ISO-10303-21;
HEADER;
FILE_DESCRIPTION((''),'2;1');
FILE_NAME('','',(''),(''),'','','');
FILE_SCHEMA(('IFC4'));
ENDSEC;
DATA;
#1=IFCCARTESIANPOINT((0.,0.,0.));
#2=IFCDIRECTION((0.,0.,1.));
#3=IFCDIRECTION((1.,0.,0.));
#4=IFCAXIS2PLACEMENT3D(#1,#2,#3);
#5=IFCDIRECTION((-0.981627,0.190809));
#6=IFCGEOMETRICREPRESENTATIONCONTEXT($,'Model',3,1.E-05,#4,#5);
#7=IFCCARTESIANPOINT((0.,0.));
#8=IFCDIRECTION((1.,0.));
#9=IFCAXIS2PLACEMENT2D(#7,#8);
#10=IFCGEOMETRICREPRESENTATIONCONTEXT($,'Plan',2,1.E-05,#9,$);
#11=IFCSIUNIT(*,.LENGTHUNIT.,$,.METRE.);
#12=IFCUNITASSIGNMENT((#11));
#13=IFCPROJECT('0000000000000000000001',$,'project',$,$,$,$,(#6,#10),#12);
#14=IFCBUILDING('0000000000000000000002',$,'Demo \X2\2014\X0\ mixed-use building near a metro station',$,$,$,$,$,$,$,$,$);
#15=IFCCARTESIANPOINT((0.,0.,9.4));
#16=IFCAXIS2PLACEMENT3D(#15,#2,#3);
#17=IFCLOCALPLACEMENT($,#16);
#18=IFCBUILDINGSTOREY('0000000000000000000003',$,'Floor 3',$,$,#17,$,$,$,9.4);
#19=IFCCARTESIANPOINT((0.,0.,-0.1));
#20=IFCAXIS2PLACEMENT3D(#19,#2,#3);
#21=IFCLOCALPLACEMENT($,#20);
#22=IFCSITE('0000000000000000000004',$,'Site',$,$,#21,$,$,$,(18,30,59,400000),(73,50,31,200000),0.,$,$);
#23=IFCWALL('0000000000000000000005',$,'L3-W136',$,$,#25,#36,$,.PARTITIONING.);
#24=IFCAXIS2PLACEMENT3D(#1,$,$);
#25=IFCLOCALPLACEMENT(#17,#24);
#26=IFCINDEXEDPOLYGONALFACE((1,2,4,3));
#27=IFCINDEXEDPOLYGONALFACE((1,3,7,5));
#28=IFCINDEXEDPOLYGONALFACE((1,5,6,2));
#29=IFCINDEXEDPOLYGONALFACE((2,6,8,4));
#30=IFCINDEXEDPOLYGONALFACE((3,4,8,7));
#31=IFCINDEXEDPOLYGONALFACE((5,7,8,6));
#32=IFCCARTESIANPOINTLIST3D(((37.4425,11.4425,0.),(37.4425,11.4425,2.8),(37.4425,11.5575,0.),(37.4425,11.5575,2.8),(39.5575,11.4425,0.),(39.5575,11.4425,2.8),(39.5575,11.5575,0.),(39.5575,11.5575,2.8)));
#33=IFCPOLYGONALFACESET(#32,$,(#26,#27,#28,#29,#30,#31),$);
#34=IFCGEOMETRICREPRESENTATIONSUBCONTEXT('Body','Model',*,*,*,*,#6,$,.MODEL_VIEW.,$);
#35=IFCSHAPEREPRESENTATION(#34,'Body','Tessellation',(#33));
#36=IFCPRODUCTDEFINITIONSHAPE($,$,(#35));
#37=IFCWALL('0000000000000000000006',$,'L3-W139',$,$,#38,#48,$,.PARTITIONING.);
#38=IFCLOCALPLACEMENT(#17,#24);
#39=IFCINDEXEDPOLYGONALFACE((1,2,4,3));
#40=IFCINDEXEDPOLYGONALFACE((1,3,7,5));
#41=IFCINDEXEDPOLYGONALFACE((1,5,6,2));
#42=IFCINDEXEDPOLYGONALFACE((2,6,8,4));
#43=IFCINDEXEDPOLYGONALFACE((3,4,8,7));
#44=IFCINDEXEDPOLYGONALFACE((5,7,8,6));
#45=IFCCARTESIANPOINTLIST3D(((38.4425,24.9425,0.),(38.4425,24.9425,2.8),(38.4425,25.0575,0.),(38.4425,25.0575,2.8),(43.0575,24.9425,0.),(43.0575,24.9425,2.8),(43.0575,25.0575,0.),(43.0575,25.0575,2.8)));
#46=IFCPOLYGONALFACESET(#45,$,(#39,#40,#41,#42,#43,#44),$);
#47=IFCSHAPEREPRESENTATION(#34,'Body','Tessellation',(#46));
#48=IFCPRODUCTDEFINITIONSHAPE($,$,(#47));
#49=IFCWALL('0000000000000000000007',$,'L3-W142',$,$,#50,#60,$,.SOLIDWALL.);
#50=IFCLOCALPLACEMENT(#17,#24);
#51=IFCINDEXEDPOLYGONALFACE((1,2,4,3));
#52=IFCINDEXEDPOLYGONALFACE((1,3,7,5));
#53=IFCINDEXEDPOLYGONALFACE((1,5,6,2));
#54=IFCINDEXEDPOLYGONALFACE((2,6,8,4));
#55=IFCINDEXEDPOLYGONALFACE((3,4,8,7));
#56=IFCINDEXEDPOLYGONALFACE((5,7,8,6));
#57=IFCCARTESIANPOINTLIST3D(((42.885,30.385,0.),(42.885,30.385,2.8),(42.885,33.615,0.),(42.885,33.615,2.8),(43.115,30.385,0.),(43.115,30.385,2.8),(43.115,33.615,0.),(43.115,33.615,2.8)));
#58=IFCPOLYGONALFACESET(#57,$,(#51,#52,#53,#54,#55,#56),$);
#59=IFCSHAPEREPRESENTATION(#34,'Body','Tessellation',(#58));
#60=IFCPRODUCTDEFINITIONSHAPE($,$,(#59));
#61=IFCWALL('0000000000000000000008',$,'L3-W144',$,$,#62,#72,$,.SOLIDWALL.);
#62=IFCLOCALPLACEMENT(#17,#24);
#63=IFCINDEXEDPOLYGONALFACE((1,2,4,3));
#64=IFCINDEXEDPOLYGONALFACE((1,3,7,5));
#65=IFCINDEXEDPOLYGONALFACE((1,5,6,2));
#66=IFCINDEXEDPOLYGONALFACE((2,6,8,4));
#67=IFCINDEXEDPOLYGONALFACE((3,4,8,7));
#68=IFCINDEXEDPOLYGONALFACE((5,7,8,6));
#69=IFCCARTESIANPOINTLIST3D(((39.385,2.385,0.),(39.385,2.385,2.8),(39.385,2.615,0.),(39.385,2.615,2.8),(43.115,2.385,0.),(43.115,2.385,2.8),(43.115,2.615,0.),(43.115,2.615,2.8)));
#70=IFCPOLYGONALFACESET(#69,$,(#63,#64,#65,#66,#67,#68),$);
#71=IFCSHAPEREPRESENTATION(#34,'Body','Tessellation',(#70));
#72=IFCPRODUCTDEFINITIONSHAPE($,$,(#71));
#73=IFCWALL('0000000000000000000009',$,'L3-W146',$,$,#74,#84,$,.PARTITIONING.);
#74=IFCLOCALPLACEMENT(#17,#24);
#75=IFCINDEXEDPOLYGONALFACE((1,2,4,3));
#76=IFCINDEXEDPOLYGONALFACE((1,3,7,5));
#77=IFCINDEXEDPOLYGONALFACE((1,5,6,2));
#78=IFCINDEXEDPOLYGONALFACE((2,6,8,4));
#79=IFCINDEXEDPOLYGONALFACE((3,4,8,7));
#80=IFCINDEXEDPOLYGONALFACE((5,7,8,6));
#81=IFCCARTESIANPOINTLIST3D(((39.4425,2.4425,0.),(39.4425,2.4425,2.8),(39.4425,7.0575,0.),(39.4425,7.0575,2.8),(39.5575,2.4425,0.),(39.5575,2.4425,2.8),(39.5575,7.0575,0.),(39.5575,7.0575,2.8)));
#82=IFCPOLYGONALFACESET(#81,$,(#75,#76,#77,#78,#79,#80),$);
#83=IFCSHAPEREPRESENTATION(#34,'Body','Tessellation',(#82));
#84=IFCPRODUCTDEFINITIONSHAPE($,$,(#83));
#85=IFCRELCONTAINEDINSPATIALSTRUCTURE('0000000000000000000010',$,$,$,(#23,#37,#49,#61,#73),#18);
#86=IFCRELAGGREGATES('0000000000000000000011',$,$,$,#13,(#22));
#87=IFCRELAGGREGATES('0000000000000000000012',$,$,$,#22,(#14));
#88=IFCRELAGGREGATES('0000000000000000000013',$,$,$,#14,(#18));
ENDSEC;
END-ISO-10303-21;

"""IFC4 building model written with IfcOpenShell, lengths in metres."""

from ifc_helpers import new_model, si_unit, direction, frame, origin_with_axes, origin_2d_with_axis, place, context, subcontext, project, spatial, line, indexed_curve, outline, extrude, element, save


model = new_model("IFC4")

# Units and contexts
model_context = context("Model", 3, precision=1e-05, world=origin_with_axes(), true_north=direction((-0.981627, 0.190809)))
plan_context = context("Plan", 2, precision=1e-05, world=origin_2d_with_axis())
body_context = subcontext(model_context, "Body", "Model", "MODEL_VIEW")
ifc_project = project(units=[si_unit("LENGTHUNIT", "METRE")], contexts=[model_context, plan_context])

# Site, building, storey
site_placement = place(None, frame((0.0, 0.0, -0.1), z_axis=(0.0, 0.0, 1.0), x_axis=(1.0, 0.0, 0.0)))
site = spatial("IfcSite", under=ifc_project, at=site_placement, Name="Site", RefLatitude=(18, 30, 59, 400000), RefLongitude=(73, 50, 31, 200000), RefElevation=0.0)
building = spatial("IfcBuilding", under=site, Name="Demo — mixed-use building near a metro station")
storey_placement = place(None, frame((0.0, 0.0, 9.4), z_axis=(0.0, 0.0, 1.0), x_axis=(1.0, 0.0, 0.0)))
storey = spatial("IfcBuildingStorey", under=building, at=storey_placement, Name="Floor 3", Elevation=9.4)

# Wall
wall_1_placement = place(storey_placement, frame((0.0, 0.0, -9.4), z_axis=(0.0, 0.0, 1.0), x_axis=(1.0, 0.0, 0.0)))
element("IfcWall", 1, at=wall_1_placement, inside=storey, Name="L3-W136", PredefinedType="PARTITIONING", context=body_context, shape_type="SweptSolid", body=[
    extrude(outline(indexed_curve([(37.4425, 11.5575), (39.5575, 11.5575), (39.5575, 11.4425), (37.4425, 11.4425)], segments=[line(1, 2, 3, 4, 1)])), frame((0.0, 0.0, 9.4), z_axis=(0.0, 0.0, 1.0), x_axis=(1.0, 0.0, 0.0)), (0.0, 0.0, 1.0), 2.8),
])

# Wall
wall_2_placement = place(storey_placement, frame((0.0, 0.0, -9.4), z_axis=(0.0, 0.0, 1.0), x_axis=(1.0, 0.0, 0.0)))
element("IfcWall", 2, at=wall_2_placement, inside=storey, Name="L3-W139", PredefinedType="PARTITIONING", context=body_context, shape_type="SweptSolid", body=[
    extrude(outline(indexed_curve([(43.0575, 24.9425), (38.4425, 24.9425), (38.4425, 25.0575), (43.0575, 25.0575)], segments=[line(1, 2, 3, 4, 1)])), frame((0.0, 0.0, 9.4), z_axis=(0.0, 0.0, 1.0), x_axis=(1.0, 0.0, 0.0)), (0.0, 0.0, 1.0), 2.8),
])

# Wall
wall_3_placement = place(storey_placement, frame((0.0, 0.0, -9.4), z_axis=(0.0, 0.0, 1.0), x_axis=(1.0, 0.0, 0.0)))
element("IfcWall", 3, at=wall_3_placement, inside=storey, Name="L3-W142", PredefinedType="SOLIDWALL", context=body_context, shape_type="SweptSolid", body=[
    extrude(outline(indexed_curve([(42.885, 30.385), (42.885, 33.615), (43.115, 33.615), (43.115, 30.385)], segments=[line(1, 2, 3, 4, 1)])), frame((0.0, 0.0, 9.4), z_axis=(0.0, 0.0, 1.0), x_axis=(1.0, 0.0, 0.0)), (0.0, 0.0, 1.0), 2.8),
])

# Wall
wall_4_placement = place(storey_placement, frame((0.0, 0.0, -9.4), z_axis=(0.0, 0.0, 1.0), x_axis=(1.0, 0.0, 0.0)))
element("IfcWall", 4, at=wall_4_placement, inside=storey, Name="L3-W144", PredefinedType="SOLIDWALL", context=body_context, shape_type="SweptSolid", body=[
    extrude(outline(indexed_curve([(39.385, 2.615), (43.115, 2.615), (43.115, 2.385), (39.385, 2.385)], segments=[line(1, 2, 3, 4, 1)])), frame((0.0, 0.0, 9.4), z_axis=(0.0, 0.0, 1.0), x_axis=(1.0, 0.0, 0.0)), (0.0, 0.0, 1.0), 2.8),
])

# Wall
wall_5_placement = place(storey_placement, frame((0.0, 0.0, -9.4), z_axis=(0.0, 0.0, 1.0), x_axis=(1.0, 0.0, 0.0)))
element("IfcWall", 5, at=wall_5_placement, inside=storey, Name="L3-W146", PredefinedType="PARTITIONING", context=body_context, shape_type="SweptSolid", body=[
    extrude(outline(indexed_curve([(39.5575, 7.0575), (39.5575, 2.4425), (39.4425, 2.4425), (39.4425, 7.0575)], segments=[line(1, 2, 3, 4, 1)])), frame((0.0, 0.0, 9.4), z_axis=(0.0, 0.0, 1.0), x_axis=(1.0, 0.0, 0.0)), (0.0, 0.0, 1.0), 2.8),
])

save(model, "model.ifc")
